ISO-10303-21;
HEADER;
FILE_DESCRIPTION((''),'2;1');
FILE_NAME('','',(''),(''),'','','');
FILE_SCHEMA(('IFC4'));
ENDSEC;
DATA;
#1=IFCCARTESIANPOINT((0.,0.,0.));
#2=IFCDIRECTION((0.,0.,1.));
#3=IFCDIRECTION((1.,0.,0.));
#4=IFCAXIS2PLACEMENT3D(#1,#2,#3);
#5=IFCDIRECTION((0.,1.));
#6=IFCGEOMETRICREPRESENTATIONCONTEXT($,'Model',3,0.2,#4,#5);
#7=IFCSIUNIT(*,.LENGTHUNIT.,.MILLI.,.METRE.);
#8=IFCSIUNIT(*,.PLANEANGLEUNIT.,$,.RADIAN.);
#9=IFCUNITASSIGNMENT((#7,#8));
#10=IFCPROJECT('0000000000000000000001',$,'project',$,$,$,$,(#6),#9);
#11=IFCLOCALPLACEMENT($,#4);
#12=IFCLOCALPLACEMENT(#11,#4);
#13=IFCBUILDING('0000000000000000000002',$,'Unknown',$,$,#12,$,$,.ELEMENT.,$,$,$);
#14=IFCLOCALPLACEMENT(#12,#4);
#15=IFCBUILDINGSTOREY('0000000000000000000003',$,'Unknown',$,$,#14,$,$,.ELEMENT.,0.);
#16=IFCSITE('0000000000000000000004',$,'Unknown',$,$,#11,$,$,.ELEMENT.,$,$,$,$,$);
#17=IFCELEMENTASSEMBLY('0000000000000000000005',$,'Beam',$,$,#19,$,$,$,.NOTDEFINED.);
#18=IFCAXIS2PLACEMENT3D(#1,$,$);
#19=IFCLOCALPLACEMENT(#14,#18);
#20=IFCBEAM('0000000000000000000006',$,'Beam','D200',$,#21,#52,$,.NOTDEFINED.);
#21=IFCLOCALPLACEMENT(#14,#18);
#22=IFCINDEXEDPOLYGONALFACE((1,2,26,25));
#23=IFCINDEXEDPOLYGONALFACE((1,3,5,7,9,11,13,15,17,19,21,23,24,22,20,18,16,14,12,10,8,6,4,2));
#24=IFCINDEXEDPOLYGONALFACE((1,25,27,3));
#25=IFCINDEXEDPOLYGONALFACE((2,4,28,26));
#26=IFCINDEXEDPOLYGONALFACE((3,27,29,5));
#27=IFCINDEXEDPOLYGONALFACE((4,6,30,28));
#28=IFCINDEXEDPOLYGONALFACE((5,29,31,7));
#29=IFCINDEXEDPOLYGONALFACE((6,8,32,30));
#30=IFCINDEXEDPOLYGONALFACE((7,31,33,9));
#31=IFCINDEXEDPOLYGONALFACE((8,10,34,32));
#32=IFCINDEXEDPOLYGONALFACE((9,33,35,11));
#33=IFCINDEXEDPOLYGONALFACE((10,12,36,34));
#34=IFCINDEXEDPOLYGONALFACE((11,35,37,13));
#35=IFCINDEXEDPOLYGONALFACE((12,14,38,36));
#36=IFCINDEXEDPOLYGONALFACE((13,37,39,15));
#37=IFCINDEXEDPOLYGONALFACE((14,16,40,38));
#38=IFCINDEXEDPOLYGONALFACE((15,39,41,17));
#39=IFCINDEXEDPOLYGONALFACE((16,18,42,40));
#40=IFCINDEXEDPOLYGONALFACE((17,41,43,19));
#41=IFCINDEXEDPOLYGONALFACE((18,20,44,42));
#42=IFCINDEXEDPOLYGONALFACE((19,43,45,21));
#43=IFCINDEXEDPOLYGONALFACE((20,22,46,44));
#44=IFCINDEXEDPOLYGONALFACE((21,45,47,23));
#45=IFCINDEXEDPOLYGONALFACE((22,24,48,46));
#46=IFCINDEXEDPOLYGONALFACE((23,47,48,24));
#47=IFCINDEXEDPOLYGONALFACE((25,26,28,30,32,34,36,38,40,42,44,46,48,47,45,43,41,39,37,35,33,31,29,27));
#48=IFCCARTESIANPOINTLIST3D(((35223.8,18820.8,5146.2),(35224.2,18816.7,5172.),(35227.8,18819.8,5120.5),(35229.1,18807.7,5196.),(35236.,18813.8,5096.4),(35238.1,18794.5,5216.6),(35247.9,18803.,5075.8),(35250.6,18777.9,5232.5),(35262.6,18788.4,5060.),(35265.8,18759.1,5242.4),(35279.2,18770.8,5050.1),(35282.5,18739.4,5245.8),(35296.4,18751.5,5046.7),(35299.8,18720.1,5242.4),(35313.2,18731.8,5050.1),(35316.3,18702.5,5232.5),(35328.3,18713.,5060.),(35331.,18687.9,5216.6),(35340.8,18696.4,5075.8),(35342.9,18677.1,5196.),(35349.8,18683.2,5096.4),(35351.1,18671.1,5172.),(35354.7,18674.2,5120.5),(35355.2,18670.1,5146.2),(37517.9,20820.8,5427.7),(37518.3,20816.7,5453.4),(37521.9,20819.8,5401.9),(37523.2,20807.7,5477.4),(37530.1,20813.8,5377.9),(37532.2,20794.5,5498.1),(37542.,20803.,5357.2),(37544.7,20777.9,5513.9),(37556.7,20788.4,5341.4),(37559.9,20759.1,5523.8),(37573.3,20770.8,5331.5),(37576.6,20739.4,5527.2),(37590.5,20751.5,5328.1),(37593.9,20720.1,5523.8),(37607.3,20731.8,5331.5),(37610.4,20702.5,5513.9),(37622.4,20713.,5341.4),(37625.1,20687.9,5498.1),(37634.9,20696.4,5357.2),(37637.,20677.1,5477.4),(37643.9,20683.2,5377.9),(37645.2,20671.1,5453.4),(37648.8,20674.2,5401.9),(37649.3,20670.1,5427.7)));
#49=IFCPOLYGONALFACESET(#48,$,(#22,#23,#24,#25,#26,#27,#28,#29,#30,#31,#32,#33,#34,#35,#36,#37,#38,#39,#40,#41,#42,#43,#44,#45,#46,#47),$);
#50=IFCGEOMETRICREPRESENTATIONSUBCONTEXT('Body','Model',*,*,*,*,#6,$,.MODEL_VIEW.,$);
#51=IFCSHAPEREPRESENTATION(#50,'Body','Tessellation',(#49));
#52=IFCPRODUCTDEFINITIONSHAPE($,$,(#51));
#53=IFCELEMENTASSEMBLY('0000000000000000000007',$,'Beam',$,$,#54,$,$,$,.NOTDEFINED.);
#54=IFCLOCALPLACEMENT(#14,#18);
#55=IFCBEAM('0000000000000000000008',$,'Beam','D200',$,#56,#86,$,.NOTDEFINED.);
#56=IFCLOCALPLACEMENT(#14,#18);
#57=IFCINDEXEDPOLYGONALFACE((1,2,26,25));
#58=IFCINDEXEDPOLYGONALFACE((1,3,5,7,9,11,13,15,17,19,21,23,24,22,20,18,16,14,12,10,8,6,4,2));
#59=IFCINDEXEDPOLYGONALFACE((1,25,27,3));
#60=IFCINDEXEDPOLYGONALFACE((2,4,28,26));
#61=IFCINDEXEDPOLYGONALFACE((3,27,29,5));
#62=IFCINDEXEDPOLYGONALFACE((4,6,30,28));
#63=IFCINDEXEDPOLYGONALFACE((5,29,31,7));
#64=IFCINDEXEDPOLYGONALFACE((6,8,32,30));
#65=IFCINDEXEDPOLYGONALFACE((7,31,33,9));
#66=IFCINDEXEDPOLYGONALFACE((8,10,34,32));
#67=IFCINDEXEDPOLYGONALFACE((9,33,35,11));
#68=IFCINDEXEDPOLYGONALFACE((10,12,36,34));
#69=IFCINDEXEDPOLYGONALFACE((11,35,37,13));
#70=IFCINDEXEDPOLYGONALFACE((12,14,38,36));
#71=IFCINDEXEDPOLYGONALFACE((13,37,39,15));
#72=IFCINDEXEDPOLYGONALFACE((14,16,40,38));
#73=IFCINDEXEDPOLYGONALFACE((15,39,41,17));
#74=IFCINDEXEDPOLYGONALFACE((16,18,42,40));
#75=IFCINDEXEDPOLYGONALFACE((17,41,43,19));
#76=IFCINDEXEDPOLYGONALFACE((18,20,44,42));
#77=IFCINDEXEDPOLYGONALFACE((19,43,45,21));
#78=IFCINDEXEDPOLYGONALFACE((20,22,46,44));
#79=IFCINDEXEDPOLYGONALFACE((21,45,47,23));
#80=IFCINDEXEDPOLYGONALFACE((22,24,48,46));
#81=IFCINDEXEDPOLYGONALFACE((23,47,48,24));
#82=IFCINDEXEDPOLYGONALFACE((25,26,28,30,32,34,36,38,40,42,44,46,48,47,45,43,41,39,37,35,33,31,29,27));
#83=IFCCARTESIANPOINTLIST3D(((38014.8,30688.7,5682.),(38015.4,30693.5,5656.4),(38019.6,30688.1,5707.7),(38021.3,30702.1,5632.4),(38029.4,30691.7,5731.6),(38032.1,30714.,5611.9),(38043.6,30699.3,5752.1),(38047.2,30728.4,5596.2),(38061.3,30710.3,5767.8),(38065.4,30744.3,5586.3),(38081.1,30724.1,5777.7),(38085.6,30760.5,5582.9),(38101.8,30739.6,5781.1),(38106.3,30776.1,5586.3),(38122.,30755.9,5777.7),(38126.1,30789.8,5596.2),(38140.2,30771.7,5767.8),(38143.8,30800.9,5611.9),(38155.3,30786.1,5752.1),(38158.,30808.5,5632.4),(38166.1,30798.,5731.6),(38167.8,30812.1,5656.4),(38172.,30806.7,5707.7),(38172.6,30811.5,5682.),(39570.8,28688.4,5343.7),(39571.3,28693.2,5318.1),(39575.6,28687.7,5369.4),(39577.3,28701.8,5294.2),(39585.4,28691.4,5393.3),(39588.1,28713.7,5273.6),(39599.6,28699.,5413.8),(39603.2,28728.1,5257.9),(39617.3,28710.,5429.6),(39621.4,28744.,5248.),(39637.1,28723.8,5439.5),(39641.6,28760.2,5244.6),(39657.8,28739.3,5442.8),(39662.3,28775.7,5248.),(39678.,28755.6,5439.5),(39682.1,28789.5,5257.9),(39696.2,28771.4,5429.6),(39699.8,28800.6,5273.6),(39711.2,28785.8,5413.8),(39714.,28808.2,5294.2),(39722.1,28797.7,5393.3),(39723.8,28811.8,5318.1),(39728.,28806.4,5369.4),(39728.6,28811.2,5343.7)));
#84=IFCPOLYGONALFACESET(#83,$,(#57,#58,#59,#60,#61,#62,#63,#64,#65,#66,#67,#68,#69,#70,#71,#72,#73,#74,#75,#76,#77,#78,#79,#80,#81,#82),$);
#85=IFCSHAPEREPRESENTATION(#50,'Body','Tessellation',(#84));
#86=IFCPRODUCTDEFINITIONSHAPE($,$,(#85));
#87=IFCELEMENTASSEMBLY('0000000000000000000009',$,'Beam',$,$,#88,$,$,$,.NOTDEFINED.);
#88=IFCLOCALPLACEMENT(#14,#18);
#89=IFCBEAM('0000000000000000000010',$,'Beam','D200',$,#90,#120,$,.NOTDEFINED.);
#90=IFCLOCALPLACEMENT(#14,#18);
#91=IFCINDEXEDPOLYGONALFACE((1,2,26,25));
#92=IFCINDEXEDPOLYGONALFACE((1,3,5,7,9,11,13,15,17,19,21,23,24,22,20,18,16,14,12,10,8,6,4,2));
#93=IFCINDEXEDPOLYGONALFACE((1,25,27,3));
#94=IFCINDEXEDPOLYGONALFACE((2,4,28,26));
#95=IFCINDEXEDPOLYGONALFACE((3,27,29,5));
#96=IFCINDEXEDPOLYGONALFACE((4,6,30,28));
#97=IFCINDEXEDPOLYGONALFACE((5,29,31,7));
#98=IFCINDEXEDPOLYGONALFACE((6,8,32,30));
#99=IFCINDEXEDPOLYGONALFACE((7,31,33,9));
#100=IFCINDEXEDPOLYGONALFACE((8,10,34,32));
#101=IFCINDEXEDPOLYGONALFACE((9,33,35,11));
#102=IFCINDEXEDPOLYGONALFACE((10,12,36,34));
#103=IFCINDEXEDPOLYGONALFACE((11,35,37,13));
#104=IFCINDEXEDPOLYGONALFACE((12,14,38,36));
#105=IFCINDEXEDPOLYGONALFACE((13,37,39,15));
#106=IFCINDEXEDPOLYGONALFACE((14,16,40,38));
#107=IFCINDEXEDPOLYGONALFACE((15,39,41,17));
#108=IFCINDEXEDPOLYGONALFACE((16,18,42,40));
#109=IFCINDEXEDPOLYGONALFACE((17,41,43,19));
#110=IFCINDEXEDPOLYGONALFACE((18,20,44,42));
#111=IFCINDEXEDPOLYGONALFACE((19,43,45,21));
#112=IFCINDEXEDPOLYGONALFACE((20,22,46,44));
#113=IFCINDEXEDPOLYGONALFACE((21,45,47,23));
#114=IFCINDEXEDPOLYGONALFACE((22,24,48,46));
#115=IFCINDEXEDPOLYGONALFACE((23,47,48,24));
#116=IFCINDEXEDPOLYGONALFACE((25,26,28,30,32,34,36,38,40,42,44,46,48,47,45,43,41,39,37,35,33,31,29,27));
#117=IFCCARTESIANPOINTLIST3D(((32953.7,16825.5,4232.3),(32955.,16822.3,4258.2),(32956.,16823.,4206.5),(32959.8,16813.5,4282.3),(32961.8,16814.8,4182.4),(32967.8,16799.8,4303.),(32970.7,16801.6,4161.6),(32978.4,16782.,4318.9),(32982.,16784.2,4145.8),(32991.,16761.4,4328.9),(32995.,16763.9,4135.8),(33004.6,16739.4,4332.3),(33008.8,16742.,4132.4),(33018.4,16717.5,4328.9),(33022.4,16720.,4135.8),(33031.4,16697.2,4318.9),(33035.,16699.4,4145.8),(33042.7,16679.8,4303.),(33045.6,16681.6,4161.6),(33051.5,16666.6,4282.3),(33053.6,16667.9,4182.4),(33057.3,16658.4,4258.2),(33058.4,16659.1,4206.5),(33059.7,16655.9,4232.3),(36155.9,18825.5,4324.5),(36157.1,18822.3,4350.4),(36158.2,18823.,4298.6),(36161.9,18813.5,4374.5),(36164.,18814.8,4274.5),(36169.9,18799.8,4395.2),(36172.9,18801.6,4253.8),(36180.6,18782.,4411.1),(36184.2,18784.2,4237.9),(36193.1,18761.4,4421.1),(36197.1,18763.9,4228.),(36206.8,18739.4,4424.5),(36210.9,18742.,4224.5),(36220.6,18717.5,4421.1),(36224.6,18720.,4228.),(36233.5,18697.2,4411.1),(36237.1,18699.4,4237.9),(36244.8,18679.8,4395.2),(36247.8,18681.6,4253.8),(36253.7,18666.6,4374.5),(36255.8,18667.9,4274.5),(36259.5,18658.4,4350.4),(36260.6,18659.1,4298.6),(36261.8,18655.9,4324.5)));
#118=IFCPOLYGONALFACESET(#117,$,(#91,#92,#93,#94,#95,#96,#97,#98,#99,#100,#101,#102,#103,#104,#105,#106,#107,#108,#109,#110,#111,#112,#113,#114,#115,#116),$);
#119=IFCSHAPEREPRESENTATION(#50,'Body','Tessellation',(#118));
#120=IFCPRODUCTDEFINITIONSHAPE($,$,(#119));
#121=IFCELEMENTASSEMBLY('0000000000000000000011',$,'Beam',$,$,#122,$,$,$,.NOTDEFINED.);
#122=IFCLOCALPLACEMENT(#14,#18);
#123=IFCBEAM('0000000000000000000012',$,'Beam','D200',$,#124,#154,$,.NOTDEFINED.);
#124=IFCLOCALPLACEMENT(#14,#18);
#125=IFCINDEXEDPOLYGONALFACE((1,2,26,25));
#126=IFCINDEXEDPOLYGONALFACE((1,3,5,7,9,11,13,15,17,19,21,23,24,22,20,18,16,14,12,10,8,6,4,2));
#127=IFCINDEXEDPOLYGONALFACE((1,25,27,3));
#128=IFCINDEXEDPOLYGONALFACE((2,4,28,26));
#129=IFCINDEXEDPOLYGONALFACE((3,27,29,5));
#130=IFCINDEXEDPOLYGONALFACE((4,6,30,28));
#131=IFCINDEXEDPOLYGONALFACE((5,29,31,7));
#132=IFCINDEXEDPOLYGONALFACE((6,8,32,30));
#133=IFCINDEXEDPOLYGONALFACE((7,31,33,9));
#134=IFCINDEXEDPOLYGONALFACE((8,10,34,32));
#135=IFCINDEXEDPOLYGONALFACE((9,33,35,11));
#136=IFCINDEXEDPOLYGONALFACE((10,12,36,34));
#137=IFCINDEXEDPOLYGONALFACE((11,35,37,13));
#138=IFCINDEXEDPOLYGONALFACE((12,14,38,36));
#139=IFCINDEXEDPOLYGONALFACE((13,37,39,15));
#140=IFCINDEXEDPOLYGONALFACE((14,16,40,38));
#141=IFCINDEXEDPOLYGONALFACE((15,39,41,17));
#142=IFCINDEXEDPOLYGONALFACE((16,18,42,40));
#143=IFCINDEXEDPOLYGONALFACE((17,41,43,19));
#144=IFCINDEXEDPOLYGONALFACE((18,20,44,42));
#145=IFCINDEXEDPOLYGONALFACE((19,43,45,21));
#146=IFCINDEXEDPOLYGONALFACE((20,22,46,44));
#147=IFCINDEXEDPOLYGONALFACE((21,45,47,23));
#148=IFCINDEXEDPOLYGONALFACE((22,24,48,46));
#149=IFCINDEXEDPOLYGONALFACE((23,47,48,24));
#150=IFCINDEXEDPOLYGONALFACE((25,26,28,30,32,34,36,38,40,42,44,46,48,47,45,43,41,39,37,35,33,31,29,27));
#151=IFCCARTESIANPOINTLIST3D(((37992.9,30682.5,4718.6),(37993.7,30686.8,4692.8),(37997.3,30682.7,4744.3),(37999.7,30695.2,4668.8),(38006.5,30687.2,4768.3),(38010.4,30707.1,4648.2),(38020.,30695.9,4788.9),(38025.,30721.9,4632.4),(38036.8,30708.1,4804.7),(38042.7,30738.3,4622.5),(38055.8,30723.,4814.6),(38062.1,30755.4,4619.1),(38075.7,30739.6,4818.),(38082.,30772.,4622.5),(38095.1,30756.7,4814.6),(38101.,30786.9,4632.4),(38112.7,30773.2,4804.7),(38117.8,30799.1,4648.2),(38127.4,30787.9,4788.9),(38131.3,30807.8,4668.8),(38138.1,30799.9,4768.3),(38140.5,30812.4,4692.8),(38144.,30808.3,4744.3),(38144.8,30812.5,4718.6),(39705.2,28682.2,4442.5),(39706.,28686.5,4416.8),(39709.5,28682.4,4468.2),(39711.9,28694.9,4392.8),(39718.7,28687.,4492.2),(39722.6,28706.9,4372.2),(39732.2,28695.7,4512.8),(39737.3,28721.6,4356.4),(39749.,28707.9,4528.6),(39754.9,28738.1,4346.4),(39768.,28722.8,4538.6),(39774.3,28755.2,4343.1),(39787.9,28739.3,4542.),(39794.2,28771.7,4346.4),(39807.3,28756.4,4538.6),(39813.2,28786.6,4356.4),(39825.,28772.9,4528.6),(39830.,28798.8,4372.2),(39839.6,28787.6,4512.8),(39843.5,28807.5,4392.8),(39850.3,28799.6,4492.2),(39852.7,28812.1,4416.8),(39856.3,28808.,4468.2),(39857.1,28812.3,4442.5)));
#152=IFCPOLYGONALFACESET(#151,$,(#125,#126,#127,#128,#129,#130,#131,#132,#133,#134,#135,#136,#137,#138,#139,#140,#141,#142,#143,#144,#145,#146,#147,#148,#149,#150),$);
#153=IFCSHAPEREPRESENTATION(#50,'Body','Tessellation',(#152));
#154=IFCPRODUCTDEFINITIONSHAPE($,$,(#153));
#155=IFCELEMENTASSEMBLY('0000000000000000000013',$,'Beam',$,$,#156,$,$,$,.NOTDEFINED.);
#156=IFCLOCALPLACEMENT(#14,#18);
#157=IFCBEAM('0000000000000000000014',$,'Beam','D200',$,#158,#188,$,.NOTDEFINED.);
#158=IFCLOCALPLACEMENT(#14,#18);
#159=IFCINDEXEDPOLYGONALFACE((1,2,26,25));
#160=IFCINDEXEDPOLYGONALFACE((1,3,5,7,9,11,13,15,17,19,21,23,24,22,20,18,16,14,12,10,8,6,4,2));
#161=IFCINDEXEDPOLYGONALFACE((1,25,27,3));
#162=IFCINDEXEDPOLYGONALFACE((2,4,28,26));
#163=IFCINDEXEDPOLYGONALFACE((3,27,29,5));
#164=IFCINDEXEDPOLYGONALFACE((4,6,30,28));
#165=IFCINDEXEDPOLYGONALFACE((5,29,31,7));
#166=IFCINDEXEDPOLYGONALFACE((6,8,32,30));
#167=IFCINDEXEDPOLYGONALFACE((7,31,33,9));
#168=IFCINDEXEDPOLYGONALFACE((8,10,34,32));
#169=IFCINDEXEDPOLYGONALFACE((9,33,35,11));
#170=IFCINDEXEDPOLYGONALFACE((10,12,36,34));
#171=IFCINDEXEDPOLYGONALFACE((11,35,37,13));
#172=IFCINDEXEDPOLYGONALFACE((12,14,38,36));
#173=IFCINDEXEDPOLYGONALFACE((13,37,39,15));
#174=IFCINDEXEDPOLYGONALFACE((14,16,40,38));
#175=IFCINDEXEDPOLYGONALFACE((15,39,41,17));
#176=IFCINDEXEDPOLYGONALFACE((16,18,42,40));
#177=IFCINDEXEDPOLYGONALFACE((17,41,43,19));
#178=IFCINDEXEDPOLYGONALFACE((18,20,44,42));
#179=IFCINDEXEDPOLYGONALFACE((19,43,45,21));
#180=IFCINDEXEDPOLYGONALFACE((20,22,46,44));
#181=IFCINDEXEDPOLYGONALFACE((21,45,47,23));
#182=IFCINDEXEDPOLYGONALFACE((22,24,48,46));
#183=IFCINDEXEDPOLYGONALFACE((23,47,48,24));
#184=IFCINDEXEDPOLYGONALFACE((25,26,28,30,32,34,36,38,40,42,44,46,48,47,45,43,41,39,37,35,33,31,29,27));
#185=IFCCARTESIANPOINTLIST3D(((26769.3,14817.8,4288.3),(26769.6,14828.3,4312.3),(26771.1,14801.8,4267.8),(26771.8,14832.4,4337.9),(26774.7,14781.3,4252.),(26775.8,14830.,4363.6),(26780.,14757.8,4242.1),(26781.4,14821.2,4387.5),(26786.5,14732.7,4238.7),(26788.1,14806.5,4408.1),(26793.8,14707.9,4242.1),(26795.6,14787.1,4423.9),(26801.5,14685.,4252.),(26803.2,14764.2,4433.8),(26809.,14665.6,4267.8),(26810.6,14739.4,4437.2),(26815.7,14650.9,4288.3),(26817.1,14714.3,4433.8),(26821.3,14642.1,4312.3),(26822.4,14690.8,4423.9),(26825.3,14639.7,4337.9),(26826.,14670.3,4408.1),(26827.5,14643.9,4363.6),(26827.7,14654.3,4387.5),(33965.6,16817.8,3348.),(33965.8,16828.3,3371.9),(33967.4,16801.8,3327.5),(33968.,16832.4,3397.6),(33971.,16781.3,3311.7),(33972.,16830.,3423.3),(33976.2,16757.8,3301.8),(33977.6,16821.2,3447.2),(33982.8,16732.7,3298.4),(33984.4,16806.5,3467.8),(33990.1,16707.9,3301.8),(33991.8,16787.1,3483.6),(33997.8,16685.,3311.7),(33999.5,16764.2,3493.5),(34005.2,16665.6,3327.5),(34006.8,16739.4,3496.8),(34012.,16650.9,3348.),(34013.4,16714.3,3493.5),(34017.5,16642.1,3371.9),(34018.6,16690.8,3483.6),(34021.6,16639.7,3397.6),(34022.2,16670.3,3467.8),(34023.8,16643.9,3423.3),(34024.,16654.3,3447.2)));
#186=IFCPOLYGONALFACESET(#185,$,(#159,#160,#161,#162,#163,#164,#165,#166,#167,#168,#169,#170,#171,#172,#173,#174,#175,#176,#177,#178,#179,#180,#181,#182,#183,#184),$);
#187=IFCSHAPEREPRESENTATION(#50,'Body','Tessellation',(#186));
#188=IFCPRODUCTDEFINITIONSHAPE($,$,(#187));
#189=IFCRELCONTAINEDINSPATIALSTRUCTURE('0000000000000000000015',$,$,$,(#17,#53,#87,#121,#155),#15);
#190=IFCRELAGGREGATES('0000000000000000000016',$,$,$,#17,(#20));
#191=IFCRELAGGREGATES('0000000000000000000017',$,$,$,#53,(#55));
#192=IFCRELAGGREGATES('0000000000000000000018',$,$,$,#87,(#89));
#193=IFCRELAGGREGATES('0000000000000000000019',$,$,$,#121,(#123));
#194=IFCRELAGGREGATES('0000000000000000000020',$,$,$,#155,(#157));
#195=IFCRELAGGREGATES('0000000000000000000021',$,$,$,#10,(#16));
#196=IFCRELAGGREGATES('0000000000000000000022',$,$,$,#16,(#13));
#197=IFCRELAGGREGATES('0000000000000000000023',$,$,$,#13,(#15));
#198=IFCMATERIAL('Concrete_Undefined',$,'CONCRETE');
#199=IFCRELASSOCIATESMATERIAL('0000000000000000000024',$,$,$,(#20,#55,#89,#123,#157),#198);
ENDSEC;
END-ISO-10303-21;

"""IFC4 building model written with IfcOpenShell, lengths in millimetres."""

from ifc_helpers import new_model, si_unit, direction, frame, origin_with_axes, place, context, subcontext, project, spatial, line, indexed_curve, outline, extrude, material, element, aggregate, save


model = new_model("IFC4")

# Units and contexts
model_context = context("Model", 3, precision=0.2, world=origin_with_axes(), true_north=direction((0.0, 1.0)))
body_context = subcontext(model_context, "Body", "Model", "MODEL_VIEW")
ifc_project = project(units=[si_unit("LENGTHUNIT", "METRE", prefix="MILLI"), si_unit("PLANEANGLEUNIT", "RADIAN")], contexts=[model_context])

# Site, building, storey
site_placement = place(None, origin_with_axes())
site = spatial("IfcSite", under=ifc_project, at=site_placement, Name="Unknown", CompositionType="ELEMENT")
building_placement = place(site_placement, origin_with_axes())
building = spatial("IfcBuilding", under=site, at=building_placement, Name="Unknown", CompositionType="ELEMENT")
storey_placement = place(building_placement, origin_with_axes())
storey = spatial("IfcBuildingStorey", under=building, at=storey_placement, Name="Unknown", CompositionType="ELEMENT", Elevation=0.0)

# Element assemblies, beams
ifc_material = material(Name="Concrete_Undefined", Category="CONCRETE")
assembly_1_placement = place(storey_placement, frame((37583.6, 20745.5, 5427.7), z_axis=(-0.657138, 0.753771, 0.0), x_axis=(-0.750569, -0.654346, -0.092072)))
assembly_1 = element("IfcElementAssembly", 1, at=assembly_1_placement, inside=storey, Name="Beam", PredefinedType="NOTDEFINED")
beam_1_placement = place(assembly_1_placement, origin_with_axes())
beam_1 = element("IfcBeam", 2, at=beam_1_placement, material=ifc_material, Name="Beam", Description="D200", PredefinedType="NOTDEFINED", context=body_context, shape_type="SolidModel", body=[
    extrude(outline(indexed_curve([(100.0, 0.0), (96.6, 25.9), (86.6, 50.0), (70.7, 70.7), (50.0, 86.6), (25.9, 96.6), (0.0, 100.0), (-25.9, 96.6), (-50.0, 86.6), (-70.7, 70.7), (-86.6, 50.0), (-96.6, 25.9), (-100.0, 0.0), (-96.6, -25.9), (-86.6, -50.0), (-70.7, -70.7), (-50.0, -86.6), (-25.9, -96.6), (0.0, -100.0), (25.9, -96.6), (50.0, -86.6), (70.7, -70.7), (86.6, -50.0), (96.6, -25.9)], segments=[line(1, 2, 3, 4, 5, 6, 7, 8, 9, 10, 11, 12, 13, 14, 15, 16, 17, 18, 19, 20, 21, 22, 23, 24, 1)])), frame((0.0, 0.0, 0.0), z_axis=(-1.0, 0.0, 0.0), x_axis=(0.0, 0.0, 1.0)), (0.0, 0.0, -1.0), 3056.5),
])
aggregate(assembly_1, [beam_1])
assembly_2_placement = place(storey_placement, frame((38093.7, 30750.1, 5682.0), z_axis=(-0.789316, -0.613987, 0.0), x_axis=(0.608589, -0.782377, -0.13231)))
assembly_2 = element("IfcElementAssembly", 3, at=assembly_2_placement, inside=storey, Name="Beam", PredefinedType="NOTDEFINED")
beam_2_placement = place(assembly_2_placement, origin_with_axes())
beam_2 = element("IfcBeam", 4, at=beam_2_placement, material=ifc_material, Name="Beam", Description="D200", PredefinedType="NOTDEFINED", context=body_context, shape_type="SolidModel", body=[
    extrude(outline(indexed_curve([(100.0, 0.0), (96.6, 25.9), (86.6, 50.0), (70.7, 70.7), (50.0, 86.6), (25.9, 96.6), (0.0, 100.0), (-25.9, 96.6), (-50.0, 86.6), (-70.7, 70.7), (-86.6, 50.0), (-96.6, 25.9), (-100.0, 0.0), (-96.6, -25.9), (-86.6, -50.0), (-70.7, -70.7), (-50.0, -86.6), (-25.9, -96.6), (0.0, -100.0), (25.9, -96.6), (50.0, -86.6), (70.7, -70.7), (86.6, -50.0), (96.6, -25.9)], segments=[line(1, 2, 3, 4, 5, 6, 7, 8, 9, 10, 11, 12, 13, 14, 15, 16, 17, 18, 19, 20, 21, 22, 23, 24, 1)])), frame((0.0, 0.0, 0.0), z_axis=(-1.0, 0.0, 0.0), x_axis=(0.0, 0.0, 1.0)), (0.0, 0.0, -1.0), 2556.7),
])
aggregate(assembly_2, [beam_2])
assembly_3_placement = place(storey_placement, frame((36208.8, 18740.7, 4324.5), z_axis=(-0.529741, 0.84816, 0.0), x_axis=(-0.847907, -0.529583, -0.024408)))
assembly_3 = element("IfcElementAssembly", 5, at=assembly_3_placement, inside=storey, Name="Beam", PredefinedType="NOTDEFINED")
beam_3_placement = place(assembly_3_placement, origin_with_axes())
beam_3 = element("IfcBeam", 6, at=beam_3_placement, material=ifc_material, Name="Beam", Description="D200", PredefinedType="NOTDEFINED", context=body_context, shape_type="SolidModel", body=[
    extrude(outline(indexed_curve([(100.0, 0.0), (96.6, 25.9), (86.6, 50.0), (70.7, 70.7), (50.0, 86.6), (25.9, 96.6), (0.0, 100.0), (-25.9, 96.6), (-50.0, 86.6), (-70.7, 70.7), (-86.6, 50.0), (-96.6, 25.9), (-100.0, 0.0), (-96.6, -25.9), (-86.6, -50.0), (-70.7, -70.7), (-50.0, -86.6), (-25.9, -96.6), (0.0, -100.0), (25.9, -96.6), (50.0, -86.6), (70.7, -70.7), (86.6, -50.0), (96.6, -25.9)], segments=[line(1, 2, 3, 4, 5, 6, 7, 8, 9, 10, 11, 12, 13, 14, 15, 16, 17, 18, 19, 20, 21, 22, 23, 24, 1)])), frame((0.0, 0.0, 0.0), z_axis=(-1.0, 0.0, 0.0), x_axis=(0.0, 0.0, 1.0)), (0.0, 0.0, -1.0), 3776.6),
])
aggregate(assembly_3, [beam_3])
assembly_4_placement = place(storey_placement, frame((38068.9, 30747.5, 4718.6), z_axis=(-0.759683, -0.650294, 0.0), x_axis=(0.646749, -0.755541, -0.104276)))
assembly_4 = element("IfcElementAssembly", 7, at=assembly_4_placement, inside=storey, Name="Beam", PredefinedType="NOTDEFINED")
beam_4_placement = place(assembly_4_placement, origin_with_axes())
beam_4 = element("IfcBeam", 8, at=beam_4_placement, material=ifc_material, Name="Beam", Description="D200", PredefinedType="NOTDEFINED", context=body_context, shape_type="SolidModel", body=[
    extrude(outline(indexed_curve([(100.0, 0.0), (96.6, 25.9), (86.6, 50.0), (70.7, 70.7), (50.0, 86.6), (25.9, 96.6), (0.0, 100.0), (-25.9, 96.6), (-50.0, 86.6), (-70.7, 70.7), (-86.6, 50.0), (-96.6, 25.9), (-100.0, 0.0), (-96.6, -25.9), (-86.6, -50.0), (-70.7, -70.7), (-50.0, -86.6), (-25.9, -96.6), (0.0, -100.0), (25.9, -96.6), (50.0, -86.6), (70.7, -70.7), (86.6, -50.0), (96.6, -25.9)], segments=[line(1, 2, 3, 4, 5, 6, 7, 8, 9, 10, 11, 12, 13, 14, 15, 16, 17, 18, 19, 20, 21, 22, 23, 24, 1)])), frame((0.0, 0.0, 0.0), z_axis=(-1.0, 0.0, 0.0), x_axis=(0.0, 0.0, 1.0)), (0.0, 0.0, -1.0), 2647.5),
])
aggregate(assembly_4, [beam_4])
assembly_5_placement = place(storey_placement, frame((33994.8, 16736.1, 3397.6), z_axis=(-0.267773, 0.963482, 0.0), x_axis=(-0.955936, -0.265676, 0.124909)))
assembly_5 = element("IfcElementAssembly", 9, at=assembly_5_placement, inside=storey, Name="Beam", PredefinedType="NOTDEFINED")
beam_5_placement = place(assembly_5_placement, origin_with_axes())
beam_5 = element("IfcBeam", 10, at=beam_5_placement, material=ifc_material, Name="Beam", Description="D200", PredefinedType="NOTDEFINED", context=body_context, shape_type="SolidModel", body=[
    extrude(outline(indexed_curve([(100.0, 0.0), (96.6, 25.9), (86.6, 50.0), (70.7, 70.7), (50.0, 86.6), (25.9, 96.6), (0.0, 100.0), (-25.9, 96.6), (-50.0, 86.6), (-70.7, 70.7), (-86.6, 50.0), (-96.6, 25.9), (-100.0, 0.0), (-96.6, -25.9), (-86.6, -50.0), (-70.7, -70.7), (-50.0, -86.6), (-25.9, -96.6), (0.0, -100.0), (25.9, -96.6), (50.0, -86.6), (70.7, -70.7), (86.6, -50.0), (96.6, -25.9)], segments=[line(1, 2, 3, 4, 5, 6, 7, 8, 9, 10, 11, 12, 13, 14, 15, 16, 17, 18, 19, 20, 21, 22, 23, 24, 1)])), frame((0.0, 0.0, 0.0), z_axis=(-1.0, 0.0, 0.0), x_axis=(0.0, 0.0, 1.0)), (0.0, 0.0, -1.0), 7528.0),
])
aggregate(assembly_5, [beam_5])

save(model, "model.ifc")
